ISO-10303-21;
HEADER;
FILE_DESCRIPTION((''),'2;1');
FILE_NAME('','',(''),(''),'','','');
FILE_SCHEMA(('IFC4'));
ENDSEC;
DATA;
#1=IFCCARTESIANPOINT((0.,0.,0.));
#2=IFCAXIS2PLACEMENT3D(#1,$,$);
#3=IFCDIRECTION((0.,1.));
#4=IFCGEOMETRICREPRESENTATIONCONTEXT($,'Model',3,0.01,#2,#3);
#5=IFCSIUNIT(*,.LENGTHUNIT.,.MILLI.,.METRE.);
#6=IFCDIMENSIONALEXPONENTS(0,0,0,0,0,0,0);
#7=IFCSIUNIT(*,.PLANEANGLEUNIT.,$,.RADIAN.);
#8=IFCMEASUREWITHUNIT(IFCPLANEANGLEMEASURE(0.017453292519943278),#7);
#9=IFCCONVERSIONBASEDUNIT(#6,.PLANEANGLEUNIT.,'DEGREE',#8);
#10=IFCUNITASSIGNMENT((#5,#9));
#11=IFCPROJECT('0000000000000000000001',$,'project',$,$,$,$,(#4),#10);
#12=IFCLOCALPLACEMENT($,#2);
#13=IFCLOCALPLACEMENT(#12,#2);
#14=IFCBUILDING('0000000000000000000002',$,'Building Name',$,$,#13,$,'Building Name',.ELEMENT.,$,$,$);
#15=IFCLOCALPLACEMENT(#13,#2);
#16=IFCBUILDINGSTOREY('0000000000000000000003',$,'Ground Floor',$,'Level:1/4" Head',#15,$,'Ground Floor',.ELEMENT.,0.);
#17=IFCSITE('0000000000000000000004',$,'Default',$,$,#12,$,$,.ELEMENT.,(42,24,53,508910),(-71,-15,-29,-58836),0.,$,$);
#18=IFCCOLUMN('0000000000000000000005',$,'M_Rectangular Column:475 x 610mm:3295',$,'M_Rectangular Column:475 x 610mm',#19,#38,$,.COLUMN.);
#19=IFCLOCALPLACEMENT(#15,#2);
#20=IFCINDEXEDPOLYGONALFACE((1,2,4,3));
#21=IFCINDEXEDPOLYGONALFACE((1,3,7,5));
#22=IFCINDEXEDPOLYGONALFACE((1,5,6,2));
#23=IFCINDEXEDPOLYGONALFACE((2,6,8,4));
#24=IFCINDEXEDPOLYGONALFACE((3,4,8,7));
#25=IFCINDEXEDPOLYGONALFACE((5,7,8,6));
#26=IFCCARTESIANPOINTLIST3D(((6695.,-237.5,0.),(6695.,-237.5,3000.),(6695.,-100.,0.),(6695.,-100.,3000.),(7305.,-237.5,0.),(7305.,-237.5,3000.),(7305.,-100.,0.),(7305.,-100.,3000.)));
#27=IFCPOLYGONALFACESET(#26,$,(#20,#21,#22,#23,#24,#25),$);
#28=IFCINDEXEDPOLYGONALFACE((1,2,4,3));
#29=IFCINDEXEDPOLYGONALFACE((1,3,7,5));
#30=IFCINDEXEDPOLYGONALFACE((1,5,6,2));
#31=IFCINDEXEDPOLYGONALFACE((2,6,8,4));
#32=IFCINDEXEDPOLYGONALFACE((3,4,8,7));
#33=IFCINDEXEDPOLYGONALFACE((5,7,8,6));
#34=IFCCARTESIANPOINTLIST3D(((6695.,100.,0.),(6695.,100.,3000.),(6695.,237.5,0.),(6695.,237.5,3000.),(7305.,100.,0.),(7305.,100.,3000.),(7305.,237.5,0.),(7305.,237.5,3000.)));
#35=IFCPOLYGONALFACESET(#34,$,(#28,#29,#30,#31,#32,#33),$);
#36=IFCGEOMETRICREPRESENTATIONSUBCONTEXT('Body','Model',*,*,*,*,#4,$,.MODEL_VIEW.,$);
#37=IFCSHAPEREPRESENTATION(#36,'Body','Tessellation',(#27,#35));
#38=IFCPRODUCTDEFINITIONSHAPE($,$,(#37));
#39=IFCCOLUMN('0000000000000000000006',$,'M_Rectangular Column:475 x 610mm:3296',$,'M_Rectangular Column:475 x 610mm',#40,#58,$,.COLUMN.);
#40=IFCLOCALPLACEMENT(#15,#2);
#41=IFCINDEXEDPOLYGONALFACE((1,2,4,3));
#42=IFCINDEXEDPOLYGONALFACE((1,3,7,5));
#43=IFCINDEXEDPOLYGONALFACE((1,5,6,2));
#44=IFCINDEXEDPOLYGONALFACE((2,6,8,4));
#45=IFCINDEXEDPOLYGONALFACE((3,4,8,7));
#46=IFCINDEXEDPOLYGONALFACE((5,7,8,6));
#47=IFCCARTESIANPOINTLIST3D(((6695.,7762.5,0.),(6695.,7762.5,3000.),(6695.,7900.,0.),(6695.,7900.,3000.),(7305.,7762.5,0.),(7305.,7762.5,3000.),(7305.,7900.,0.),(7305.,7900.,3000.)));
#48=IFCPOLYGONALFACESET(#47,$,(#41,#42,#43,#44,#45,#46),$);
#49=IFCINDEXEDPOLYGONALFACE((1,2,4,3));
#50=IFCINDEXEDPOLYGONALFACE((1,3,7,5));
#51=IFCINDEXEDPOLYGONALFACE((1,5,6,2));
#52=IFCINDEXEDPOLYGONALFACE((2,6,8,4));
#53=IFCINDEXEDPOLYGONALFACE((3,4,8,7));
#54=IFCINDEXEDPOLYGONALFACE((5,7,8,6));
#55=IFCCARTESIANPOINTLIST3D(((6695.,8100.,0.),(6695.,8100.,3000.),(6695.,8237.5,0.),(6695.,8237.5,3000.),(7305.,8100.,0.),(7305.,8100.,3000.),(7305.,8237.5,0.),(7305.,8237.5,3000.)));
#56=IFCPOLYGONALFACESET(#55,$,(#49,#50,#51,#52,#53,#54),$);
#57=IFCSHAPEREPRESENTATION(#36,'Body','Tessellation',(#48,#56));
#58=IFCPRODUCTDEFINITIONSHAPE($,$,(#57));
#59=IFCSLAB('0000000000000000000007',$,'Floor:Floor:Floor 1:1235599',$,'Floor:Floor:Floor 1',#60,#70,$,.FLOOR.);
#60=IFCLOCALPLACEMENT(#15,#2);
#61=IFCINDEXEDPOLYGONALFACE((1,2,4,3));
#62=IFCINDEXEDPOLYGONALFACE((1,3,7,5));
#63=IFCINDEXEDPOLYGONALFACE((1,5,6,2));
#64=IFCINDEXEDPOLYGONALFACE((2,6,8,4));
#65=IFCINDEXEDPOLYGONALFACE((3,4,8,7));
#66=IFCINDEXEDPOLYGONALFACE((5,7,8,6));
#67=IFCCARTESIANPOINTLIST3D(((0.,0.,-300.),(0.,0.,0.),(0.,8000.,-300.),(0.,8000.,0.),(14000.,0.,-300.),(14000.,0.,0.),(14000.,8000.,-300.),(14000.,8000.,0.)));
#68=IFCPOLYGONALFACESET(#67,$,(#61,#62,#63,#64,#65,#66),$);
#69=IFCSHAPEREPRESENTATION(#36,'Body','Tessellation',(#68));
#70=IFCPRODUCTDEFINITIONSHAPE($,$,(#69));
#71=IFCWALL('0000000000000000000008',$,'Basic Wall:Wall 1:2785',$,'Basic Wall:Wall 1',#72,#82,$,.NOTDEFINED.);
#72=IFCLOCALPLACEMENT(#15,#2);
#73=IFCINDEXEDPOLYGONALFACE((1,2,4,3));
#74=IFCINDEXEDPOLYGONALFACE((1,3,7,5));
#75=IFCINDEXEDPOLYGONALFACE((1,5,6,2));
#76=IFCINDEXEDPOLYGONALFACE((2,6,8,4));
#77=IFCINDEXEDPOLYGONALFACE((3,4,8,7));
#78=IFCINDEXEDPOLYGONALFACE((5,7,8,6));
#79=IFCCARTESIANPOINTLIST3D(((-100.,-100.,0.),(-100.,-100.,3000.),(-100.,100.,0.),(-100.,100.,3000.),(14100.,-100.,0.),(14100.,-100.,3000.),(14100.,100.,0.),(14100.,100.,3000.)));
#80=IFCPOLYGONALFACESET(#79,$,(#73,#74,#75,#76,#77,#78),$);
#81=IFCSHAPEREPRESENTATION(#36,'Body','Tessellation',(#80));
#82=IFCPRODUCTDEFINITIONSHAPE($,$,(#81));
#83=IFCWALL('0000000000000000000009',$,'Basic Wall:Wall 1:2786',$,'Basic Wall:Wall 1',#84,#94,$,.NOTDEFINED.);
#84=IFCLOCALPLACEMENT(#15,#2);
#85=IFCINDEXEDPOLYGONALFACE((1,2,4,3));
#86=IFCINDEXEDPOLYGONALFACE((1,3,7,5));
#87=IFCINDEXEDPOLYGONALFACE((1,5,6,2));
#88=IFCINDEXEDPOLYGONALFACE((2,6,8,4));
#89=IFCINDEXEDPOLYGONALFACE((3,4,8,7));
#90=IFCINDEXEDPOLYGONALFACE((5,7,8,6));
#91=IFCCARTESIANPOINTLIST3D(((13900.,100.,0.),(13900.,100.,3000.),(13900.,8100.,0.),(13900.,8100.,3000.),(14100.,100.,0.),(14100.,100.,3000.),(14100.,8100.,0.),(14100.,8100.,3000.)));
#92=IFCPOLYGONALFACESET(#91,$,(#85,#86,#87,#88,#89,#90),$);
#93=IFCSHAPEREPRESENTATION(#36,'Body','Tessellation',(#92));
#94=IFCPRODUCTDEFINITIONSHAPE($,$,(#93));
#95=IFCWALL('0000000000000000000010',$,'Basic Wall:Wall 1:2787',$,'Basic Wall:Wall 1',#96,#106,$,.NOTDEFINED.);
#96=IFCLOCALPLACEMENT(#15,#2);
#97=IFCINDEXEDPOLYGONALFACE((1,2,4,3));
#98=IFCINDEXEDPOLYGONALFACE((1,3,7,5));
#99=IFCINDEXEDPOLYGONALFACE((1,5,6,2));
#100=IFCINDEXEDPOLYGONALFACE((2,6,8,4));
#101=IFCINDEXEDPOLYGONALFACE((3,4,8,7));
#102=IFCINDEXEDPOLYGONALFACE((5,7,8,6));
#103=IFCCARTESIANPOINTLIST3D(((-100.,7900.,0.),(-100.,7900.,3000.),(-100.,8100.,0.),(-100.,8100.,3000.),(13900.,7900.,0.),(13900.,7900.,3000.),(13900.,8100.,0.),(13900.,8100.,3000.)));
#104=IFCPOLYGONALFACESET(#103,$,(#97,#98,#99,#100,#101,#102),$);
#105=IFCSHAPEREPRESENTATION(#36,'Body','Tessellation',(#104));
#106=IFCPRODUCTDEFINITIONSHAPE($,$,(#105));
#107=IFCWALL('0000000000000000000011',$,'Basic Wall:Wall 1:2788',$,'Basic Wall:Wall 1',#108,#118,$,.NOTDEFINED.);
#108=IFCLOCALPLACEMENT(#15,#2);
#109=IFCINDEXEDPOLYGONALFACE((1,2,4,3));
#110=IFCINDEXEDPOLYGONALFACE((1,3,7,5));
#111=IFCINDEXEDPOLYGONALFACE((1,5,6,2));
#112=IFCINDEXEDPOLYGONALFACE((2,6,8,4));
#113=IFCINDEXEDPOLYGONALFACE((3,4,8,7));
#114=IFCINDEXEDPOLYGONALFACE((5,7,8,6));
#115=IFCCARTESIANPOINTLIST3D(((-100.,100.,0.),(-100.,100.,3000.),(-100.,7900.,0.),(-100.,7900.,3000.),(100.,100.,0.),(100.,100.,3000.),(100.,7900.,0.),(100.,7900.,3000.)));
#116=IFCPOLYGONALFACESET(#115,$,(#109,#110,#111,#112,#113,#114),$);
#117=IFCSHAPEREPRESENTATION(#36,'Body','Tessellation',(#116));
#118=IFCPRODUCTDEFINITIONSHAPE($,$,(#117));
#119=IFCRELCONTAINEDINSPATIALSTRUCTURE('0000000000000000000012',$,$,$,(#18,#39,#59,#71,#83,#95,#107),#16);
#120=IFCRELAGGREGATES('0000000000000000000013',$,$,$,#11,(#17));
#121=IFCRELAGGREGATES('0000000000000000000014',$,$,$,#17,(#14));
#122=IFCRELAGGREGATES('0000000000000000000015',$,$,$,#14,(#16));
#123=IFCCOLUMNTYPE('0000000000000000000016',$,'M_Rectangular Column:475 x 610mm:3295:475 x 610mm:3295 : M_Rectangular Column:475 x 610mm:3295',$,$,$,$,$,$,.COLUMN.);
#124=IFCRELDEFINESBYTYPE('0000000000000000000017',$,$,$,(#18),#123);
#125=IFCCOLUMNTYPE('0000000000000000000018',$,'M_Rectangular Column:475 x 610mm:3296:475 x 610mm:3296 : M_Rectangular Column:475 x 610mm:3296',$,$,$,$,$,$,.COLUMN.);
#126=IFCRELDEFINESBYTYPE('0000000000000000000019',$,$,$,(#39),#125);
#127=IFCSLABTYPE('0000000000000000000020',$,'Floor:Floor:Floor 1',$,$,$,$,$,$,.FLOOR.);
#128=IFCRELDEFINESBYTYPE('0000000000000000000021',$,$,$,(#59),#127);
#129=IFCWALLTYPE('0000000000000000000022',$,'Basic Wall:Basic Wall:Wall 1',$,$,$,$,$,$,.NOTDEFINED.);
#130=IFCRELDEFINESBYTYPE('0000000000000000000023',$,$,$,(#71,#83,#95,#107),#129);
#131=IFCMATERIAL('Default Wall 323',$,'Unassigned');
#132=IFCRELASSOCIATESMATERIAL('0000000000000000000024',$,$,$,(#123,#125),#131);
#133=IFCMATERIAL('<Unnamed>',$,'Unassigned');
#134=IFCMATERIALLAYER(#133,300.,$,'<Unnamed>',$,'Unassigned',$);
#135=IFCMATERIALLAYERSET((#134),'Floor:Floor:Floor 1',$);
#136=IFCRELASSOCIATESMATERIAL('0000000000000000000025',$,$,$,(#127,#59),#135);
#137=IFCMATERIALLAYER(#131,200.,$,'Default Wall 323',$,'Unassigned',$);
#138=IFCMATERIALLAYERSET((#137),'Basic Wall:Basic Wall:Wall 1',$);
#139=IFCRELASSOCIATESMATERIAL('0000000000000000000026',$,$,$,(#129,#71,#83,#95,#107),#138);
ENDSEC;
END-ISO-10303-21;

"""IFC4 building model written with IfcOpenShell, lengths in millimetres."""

from ifc_helpers import new_model, entity, si_unit, converted_unit, direction, frame, frame_2d, origin, origin_2d_with_axis, place, context, subcontext, project, spatial, rectangle, extrude, source, transform, mapped, material, layer, layer_set, layer_usage, material_profile, profile_set, type_object, type_shapes, element, save


model = new_model("IFC4")

# Units and contexts
model_context = context("Model", 3, precision=0.01, world=origin(), true_north=direction((0.0, 1.0)))
body_context = subcontext(model_context, "Body", "Model", "MODEL_VIEW")
ifc_project = project(units=[si_unit("LENGTHUNIT", "METRE", prefix="MILLI"), converted_unit("PLANEANGLEUNIT", "DEGREE", entity("IfcPlaneAngleMeasure", 0.017453292519943278), si_unit("PLANEANGLEUNIT", "RADIAN"), dimensions=[0, 0, 0, 0, 0, 0, 0])], contexts=[model_context])

# Site, building, storey
site_placement = place(None, origin())
site = spatial("IfcSite", under=ifc_project, at=site_placement, Name="Default", CompositionType="ELEMENT", RefLatitude=(42, 24, 53, 508910), RefLongitude=(-71, -15, -29, -58836), RefElevation=0.0)
building_placement = place(site_placement, origin())
building = spatial("IfcBuilding", under=site, at=building_placement, Name="Building Name", LongName="Building Name", CompositionType="ELEMENT")
storey_placement = place(building_placement, origin())
storey = spatial("IfcBuildingStorey", under=building, at=storey_placement, Name="Ground Floor", ObjectType="Level:1/4\" Head", LongName="Ground Floor", CompositionType="ELEMENT", Elevation=0.0)

# Columns
ifc_material_1 = material(Name="Default Wall 323", Category="Unassigned")
ifc_material_profile_1 = material_profile(ifc_material_1, rectangle(XDim=610.0, YDim=137.5, at=origin_2d_with_axis()), Name="475 x 610mm:3295 : M_Rectangular Column:475 x 610mm:3295")
ifc_material_profile_2 = material_profile(ifc_material_1, rectangle(XDim=610.0, YDim=137.5, at=frame_2d((0.0, 0.0), x_axis=(1.0, 0.0))), Name="475 x 610mm:3295 : M_Rectangular Column:475 x 610mm:3295")
ifc_profile_set_1 = profile_set([ifc_material_profile_1, ifc_material_profile_2], Name="475 x 610mm:3295 : M_Rectangular Column:475 x 610mm:3295")
column_type_1 = type_object("IfcColumnType", Name="M_Rectangular Column:475 x 610mm:3295:475 x 610mm:3295 : M_Rectangular Column:475 x 610mm:3295", PredefinedType="COLUMN", material=ifc_profile_set_1)
shared_shape_1 = source(origin(), body_context, "Body", "SweptSolid", [
    extrude(rectangle(XDim=610.0, YDim=137.5, at=origin_2d_with_axis()), frame((7000.0, -168.7, 0.0), z_axis=(0.0, 0.0, 1.0), x_axis=(-1.0, 0.0, 0.0)), (0.0, 0.0, 1.0), 3000.0),
    extrude(rectangle(XDim=610.0, YDim=137.5, at=frame_2d((0.0, 0.0), x_axis=(1.0, 0.0))), frame((7000.0, 168.8, 0.0)), (0.0, 0.0, 1.0), 3000.0),
])
type_shapes(column_type_1, [shared_shape_1])
column_1_placement = place(storey_placement, origin())
element("IfcColumn", 1, at=column_1_placement, inside=storey, type_object=column_type_1, Name="M_Rectangular Column:475 x 610mm:3295", ObjectType="M_Rectangular Column:475 x 610mm", PredefinedType="COLUMN", context=body_context, shape_type="MappedRepresentation", body=[
    mapped(shared_shape_1, transform((0.0, 0.0, 0.0), scale=1.0)),
])
ifc_material_profile_3 = material_profile(ifc_material_1, rectangle(XDim=610.0, YDim=137.5, at=frame_2d((0.0, 0.0), x_axis=(1.0, 0.0))), Name="475 x 610mm:3296 : M_Rectangular Column:475 x 610mm:3296")
ifc_material_profile_4 = material_profile(ifc_material_1, rectangle(XDim=610.0, YDim=137.5, at=frame_2d((0.0, 0.0), x_axis=(1.0, 0.0))), Name="475 x 610mm:3296 : M_Rectangular Column:475 x 610mm:3296")
ifc_profile_set_2 = profile_set([ifc_material_profile_3, ifc_material_profile_4], Name="475 x 610mm:3296 : M_Rectangular Column:475 x 610mm:3296")
column_type_2 = type_object("IfcColumnType", Name="M_Rectangular Column:475 x 610mm:3296:475 x 610mm:3296 : M_Rectangular Column:475 x 610mm:3296", PredefinedType="COLUMN", material=ifc_profile_set_2)
shared_shape_2 = source(origin(), body_context, "Body", "SweptSolid", [
    extrude(rectangle(XDim=610.0, YDim=137.5, at=frame_2d((0.0, 0.0), x_axis=(1.0, 0.0))), frame((7000.0, 7831.3, 0.0), z_axis=(0.0, 0.0, 1.0), x_axis=(-1.0, 0.0, 0.0)), (0.0, 0.0, 1.0), 3000.0),
    extrude(rectangle(XDim=610.0, YDim=137.5, at=frame_2d((0.0, 0.0), x_axis=(1.0, 0.0))), frame((7000.0, 8168.7, 0.0)), (0.0, 0.0, 1.0), 3000.0),
])
type_shapes(column_type_2, [shared_shape_2])
column_2_placement = place(storey_placement, origin())
element("IfcColumn", 2, at=column_2_placement, inside=storey, type_object=column_type_2, Name="M_Rectangular Column:475 x 610mm:3296", ObjectType="M_Rectangular Column:475 x 610mm", PredefinedType="COLUMN", context=body_context, shape_type="MappedRepresentation", body=[
    mapped(shared_shape_2, transform((0.0, 0.0, 0.0), scale=1.0)),
])

# Slab
ifc_material_2 = material(Name="<Unnamed>", Category="Unassigned")
ifc_layer_1 = layer(ifc_material_2, 300.0, Name="<Unnamed>", Category="Unassigned")
ifc_layer_set_1 = layer_set([ifc_layer_1], Name="Floor:Floor:Floor 1")
ifc_layer_usage_1 = layer_usage(ifc_layer_set_1, "AXIS3", "POSITIVE", 0.0)
slab_type = type_object("IfcSlabType", Name="Floor:Floor:Floor 1", PredefinedType="FLOOR", material=ifc_layer_set_1)
slab_placement = place(storey_placement, origin())
element("IfcSlab", 3, at=slab_placement, inside=storey, type_object=slab_type, material=ifc_layer_usage_1, Name="Floor:Floor:Floor 1:1235599", ObjectType="Floor:Floor:Floor 1", PredefinedType="FLOOR", context=body_context, shape_type="SweptSolid", body=[
    extrude(rectangle(XDim=8000.0, YDim=14000.0, at=origin_2d_with_axis()), frame((7000.0, 4000.0, 0.0), z_axis=(0.0, 0.0, -1.0), x_axis=(0.0, 1.0, 0.0)), (0.0, 0.0, 1.0), 300.0),
])

# Walls
ifc_layer_2 = layer(ifc_material_1, 200.0, Name="Default Wall 323", Category="Unassigned")
ifc_layer_set_2 = layer_set([ifc_layer_2], Name="Basic Wall:Basic Wall:Wall 1")
ifc_layer_usage_2 = layer_usage(ifc_layer_set_2, "AXIS2", "NEGATIVE", 100.0)
wall_type = type_object("IfcWallType", Name="Basic Wall:Basic Wall:Wall 1", PredefinedType="NOTDEFINED", material=ifc_layer_set_2)
wall_1_placement = place(storey_placement, frame((-100.0, 0.0, 0.0)))
element("IfcWall", 4, at=wall_1_placement, inside=storey, type_object=wall_type, material=ifc_layer_usage_2, Name="Basic Wall:Wall 1:2785", ObjectType="Basic Wall:Wall 1", PredefinedType="NOTDEFINED", context=body_context, shape_type="SweptSolid", body=[
    extrude(rectangle(XDim=14200.0, YDim=200.0, at=frame_2d((7100.0, 0.0), x_axis=(-1.0, 0.0))), origin(), (0.0, 0.0, 1.0), 3000.0),
])
ifc_layer_usage_3 = layer_usage(ifc_layer_set_2, "AXIS2", "NEGATIVE", 100.0)
wall_2_placement = place(storey_placement, frame((14000.0, 100.0, 0.0), z_axis=(0.0, 0.0, 1.0), x_axis=(0.0, 1.0, 0.0)))
element("IfcWall", 5, at=wall_2_placement, inside=storey, type_object=wall_type, material=ifc_layer_usage_3, Name="Basic Wall:Wall 1:2786", ObjectType="Basic Wall:Wall 1", PredefinedType="NOTDEFINED", context=body_context, shape_type="SweptSolid", body=[
    extrude(rectangle(XDim=8000.0, YDim=200.0, at=frame_2d((4000.0, 0.0), x_axis=(-1.0, 0.0))), origin(), (0.0, 0.0, 1.0), 3000.0),
])
ifc_layer_usage_4 = layer_usage(ifc_layer_set_2, "AXIS2", "NEGATIVE", 100.0)
wall_3_placement = place(storey_placement, frame((13900.0, 8000.0, 0.0), z_axis=(0.0, 0.0, 1.0), x_axis=(-1.0, 0.0, 0.0)))
element("IfcWall", 6, at=wall_3_placement, inside=storey, type_object=wall_type, material=ifc_layer_usage_4, Name="Basic Wall:Wall 1:2787", ObjectType="Basic Wall:Wall 1", PredefinedType="NOTDEFINED", context=body_context, shape_type="SweptSolid", body=[
    extrude(rectangle(XDim=14000.0, YDim=200.0, at=frame_2d((7000.0, 0.0), x_axis=(-1.0, 0.0))), origin(), (0.0, 0.0, 1.0), 3000.0),
])
ifc_layer_usage_5 = layer_usage(ifc_layer_set_2, "AXIS2", "NEGATIVE", 100.0)
wall_4_placement = place(storey_placement, frame((0.0, 7900.0, 0.0), z_axis=(0.0, 0.0, 1.0), x_axis=(0.0, -1.0, 0.0)))
element("IfcWall", 7, at=wall_4_placement, inside=storey, type_object=wall_type, material=ifc_layer_usage_5, Name="Basic Wall:Wall 1:2788", ObjectType="Basic Wall:Wall 1", PredefinedType="NOTDEFINED", context=body_context, shape_type="SweptSolid", body=[
    extrude(rectangle(XDim=7800.0, YDim=200.0, at=frame_2d((3900.0, 0.0), x_axis=(-1.0, 0.0))), origin(), (0.0, 0.0, 1.0), 3000.0),
])

save(model, "model.ifc")
